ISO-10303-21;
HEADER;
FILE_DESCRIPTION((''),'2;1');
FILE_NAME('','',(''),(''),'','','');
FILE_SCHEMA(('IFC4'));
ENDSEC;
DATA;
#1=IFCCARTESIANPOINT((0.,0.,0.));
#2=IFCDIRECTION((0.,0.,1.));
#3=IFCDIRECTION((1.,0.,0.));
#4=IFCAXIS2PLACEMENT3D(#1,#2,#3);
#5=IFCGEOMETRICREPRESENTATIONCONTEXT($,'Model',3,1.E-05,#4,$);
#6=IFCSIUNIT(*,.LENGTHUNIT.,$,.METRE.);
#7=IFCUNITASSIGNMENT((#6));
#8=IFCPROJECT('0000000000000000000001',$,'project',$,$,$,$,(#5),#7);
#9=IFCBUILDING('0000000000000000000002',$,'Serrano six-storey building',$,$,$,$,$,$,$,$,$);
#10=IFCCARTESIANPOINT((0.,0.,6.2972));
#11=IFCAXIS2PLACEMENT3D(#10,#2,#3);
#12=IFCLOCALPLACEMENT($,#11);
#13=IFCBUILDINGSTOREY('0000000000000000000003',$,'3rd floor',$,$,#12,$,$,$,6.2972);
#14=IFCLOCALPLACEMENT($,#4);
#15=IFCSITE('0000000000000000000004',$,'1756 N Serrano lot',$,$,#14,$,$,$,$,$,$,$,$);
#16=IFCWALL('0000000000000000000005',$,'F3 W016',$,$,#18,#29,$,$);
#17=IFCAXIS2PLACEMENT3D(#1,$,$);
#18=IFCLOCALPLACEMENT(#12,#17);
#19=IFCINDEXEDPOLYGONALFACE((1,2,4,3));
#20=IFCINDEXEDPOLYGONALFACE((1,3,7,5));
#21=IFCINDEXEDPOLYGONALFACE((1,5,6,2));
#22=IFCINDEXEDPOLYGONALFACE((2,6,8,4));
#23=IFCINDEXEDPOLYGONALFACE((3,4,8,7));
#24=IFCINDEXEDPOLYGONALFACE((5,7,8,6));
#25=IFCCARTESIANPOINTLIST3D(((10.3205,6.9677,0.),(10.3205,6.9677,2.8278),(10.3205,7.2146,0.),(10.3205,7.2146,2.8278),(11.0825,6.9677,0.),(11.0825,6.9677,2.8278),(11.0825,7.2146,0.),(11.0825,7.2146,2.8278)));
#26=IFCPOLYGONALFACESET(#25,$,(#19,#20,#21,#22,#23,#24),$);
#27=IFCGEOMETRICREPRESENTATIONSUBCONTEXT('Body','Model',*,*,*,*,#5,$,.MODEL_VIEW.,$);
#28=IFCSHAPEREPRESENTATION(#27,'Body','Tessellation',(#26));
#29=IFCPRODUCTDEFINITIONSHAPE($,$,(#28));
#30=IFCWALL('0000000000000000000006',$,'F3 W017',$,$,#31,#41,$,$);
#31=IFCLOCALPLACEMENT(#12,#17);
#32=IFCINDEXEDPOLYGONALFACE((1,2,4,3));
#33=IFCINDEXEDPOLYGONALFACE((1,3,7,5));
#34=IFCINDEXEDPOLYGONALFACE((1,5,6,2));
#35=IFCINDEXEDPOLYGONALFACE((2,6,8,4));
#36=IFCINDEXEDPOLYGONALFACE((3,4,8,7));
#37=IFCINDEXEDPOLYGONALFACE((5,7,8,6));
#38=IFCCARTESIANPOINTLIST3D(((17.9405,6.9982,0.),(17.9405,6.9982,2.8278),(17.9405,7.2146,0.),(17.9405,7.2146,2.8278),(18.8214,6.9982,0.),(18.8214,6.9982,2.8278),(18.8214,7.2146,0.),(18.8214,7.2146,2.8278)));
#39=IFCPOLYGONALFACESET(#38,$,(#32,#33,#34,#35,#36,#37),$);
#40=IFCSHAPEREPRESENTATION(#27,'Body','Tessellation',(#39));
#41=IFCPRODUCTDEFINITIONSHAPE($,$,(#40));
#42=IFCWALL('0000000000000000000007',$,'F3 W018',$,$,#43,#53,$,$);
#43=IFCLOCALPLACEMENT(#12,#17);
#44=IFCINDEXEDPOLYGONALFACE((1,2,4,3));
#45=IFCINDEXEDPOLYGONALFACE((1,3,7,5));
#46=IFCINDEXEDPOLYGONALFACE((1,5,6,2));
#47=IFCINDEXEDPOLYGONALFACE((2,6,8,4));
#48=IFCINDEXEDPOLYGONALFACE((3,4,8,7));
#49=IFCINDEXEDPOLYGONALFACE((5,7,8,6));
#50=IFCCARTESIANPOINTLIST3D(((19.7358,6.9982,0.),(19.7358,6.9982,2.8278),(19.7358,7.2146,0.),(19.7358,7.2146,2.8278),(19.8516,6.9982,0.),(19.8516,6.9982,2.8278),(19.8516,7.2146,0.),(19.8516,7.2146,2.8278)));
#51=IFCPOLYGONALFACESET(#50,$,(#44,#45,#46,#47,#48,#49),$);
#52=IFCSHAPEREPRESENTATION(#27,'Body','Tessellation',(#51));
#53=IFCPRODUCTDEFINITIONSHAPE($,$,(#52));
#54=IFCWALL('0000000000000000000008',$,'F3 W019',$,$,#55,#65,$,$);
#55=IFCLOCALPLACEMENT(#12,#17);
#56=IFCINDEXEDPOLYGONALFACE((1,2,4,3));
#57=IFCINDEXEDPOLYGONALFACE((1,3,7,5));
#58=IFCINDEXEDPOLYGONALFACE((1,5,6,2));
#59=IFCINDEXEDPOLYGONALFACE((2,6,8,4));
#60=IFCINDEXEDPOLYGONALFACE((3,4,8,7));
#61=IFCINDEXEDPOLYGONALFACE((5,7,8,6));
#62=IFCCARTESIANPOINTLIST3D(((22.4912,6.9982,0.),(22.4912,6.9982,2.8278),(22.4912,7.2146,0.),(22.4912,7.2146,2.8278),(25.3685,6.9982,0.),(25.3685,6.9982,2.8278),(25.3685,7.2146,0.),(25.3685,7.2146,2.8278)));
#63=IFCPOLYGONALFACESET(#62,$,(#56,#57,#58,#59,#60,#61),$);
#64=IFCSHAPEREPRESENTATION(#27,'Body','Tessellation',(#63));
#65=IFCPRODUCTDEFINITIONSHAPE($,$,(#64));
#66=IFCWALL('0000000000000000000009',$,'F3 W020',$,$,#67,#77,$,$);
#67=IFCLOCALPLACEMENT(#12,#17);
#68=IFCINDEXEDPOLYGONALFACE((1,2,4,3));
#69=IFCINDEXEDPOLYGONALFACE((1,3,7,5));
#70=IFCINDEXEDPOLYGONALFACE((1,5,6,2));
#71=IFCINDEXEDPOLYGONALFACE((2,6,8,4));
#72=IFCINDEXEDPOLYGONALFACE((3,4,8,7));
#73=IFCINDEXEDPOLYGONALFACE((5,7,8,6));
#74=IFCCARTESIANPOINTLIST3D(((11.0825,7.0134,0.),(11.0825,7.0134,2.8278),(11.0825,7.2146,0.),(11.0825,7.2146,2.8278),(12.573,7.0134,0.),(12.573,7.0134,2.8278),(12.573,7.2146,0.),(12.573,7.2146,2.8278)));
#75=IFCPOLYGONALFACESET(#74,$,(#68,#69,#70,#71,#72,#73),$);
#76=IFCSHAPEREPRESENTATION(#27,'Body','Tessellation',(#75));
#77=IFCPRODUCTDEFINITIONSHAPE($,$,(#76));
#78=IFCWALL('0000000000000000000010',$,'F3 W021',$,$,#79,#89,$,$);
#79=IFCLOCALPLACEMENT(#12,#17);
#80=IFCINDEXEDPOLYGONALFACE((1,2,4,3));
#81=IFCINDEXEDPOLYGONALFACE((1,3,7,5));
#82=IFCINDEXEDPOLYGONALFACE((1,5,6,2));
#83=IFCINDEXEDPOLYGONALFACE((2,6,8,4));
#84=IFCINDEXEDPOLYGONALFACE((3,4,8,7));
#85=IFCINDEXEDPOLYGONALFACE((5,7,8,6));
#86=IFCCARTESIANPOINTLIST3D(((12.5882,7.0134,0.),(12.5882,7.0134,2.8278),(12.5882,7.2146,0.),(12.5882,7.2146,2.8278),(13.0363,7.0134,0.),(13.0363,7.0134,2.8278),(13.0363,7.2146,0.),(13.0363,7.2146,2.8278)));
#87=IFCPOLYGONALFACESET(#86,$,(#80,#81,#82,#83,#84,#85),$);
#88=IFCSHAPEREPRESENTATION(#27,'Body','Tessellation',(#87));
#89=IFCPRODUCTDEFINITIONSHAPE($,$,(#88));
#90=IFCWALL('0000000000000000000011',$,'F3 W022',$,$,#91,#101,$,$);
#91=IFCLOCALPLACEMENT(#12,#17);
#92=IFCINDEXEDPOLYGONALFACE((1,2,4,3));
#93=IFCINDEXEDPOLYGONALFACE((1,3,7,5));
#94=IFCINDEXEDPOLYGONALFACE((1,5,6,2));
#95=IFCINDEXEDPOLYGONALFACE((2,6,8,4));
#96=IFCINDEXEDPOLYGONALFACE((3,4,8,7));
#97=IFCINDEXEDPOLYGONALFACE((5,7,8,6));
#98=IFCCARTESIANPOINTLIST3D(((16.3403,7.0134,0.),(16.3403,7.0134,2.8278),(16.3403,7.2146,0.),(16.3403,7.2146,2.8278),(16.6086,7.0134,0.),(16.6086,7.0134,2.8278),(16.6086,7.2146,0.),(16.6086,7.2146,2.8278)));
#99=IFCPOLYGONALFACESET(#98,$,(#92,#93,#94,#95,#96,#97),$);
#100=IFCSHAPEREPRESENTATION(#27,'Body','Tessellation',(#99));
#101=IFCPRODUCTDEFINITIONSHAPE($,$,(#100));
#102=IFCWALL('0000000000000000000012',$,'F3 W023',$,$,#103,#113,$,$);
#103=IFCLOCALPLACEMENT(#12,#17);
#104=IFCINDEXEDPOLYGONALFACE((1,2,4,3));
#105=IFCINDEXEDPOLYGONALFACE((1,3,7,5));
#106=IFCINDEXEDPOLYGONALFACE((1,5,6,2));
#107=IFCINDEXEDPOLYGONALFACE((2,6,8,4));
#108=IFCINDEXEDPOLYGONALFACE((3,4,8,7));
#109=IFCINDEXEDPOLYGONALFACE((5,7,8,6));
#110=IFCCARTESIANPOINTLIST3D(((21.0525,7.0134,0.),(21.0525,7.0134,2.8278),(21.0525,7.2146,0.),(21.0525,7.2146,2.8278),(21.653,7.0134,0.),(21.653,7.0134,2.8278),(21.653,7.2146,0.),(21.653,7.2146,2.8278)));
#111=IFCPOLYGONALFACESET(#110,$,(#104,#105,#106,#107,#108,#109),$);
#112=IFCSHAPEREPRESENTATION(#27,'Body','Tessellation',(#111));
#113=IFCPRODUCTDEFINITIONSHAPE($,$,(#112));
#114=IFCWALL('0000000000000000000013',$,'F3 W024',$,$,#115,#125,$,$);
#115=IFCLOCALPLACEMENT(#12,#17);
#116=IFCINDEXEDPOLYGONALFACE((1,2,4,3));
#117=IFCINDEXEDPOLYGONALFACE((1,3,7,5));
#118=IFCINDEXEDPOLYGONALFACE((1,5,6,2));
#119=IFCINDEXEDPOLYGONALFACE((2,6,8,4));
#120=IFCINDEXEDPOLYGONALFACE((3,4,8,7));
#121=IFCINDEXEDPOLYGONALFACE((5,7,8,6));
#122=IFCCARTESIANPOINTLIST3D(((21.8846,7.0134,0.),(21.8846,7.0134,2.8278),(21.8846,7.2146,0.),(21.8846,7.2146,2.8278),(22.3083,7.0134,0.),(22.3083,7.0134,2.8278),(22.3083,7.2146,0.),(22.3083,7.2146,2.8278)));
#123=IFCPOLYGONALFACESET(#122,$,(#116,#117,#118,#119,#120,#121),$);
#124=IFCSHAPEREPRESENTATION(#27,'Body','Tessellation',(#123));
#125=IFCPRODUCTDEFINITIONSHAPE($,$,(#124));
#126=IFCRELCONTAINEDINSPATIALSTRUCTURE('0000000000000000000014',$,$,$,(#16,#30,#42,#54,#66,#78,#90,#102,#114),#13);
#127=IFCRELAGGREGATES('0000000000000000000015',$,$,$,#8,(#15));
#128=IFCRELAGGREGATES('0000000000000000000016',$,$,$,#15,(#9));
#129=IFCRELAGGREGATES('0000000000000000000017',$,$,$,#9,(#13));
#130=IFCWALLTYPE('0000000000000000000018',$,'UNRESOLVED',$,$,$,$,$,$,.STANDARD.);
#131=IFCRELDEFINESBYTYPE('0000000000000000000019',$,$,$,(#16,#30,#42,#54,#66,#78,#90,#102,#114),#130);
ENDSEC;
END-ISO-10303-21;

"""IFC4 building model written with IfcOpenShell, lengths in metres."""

from ifc_helpers import new_model, si_unit, frame, origin_with_axes, place, context, subcontext, project, spatial, polyline, outline, extrude, type_object, element, save


model = new_model("IFC4")

# Units and contexts
model_context = context("Model", 3, precision=1e-05, world=origin_with_axes())
body_context = subcontext(model_context, "Body", "Model", "MODEL_VIEW")
ifc_project = project(units=[si_unit("LENGTHUNIT", "METRE")], contexts=[model_context])

# Site, building, storey
site_placement = place(None, origin_with_axes())
site = spatial("IfcSite", under=ifc_project, at=site_placement, Name="1756 N Serrano lot")
building = spatial("IfcBuilding", under=site, Name="Serrano six-storey building")
storey_placement = place(None, frame((0.0, 0.0, 6.2972), z_axis=(0.0, 0.0, 1.0), x_axis=(1.0, 0.0, 0.0)))
storey = spatial("IfcBuildingStorey", under=building, at=storey_placement, Name="3rd floor", Elevation=6.2972)

# Walls
wall_type = type_object("IfcWallType", Name="UNRESOLVED", PredefinedType="STANDARD")
wall_1_placement = place(storey_placement, frame((0.0, 0.0, -6.2972), z_axis=(0.0, 0.0, 1.0), x_axis=(1.0, 0.0, 0.0)))
element("IfcWall", 1, at=wall_1_placement, inside=storey, type_object=wall_type, Name="F3 W016", context=body_context, shape_type="SweptSolid", body=[
    extrude(outline(polyline([(11.0825, 7.2146), (11.0825, 6.9677), (10.3205, 6.9677), (10.3205, 7.2146), (11.0825, 7.2146)])), frame((0.0, 0.0, 6.2972)), (0.0, 0.0, 1.0), 2.8278),
])
wall_2_placement = place(storey_placement, frame((0.0, 0.0, -6.2972), z_axis=(0.0, 0.0, 1.0), x_axis=(1.0, 0.0, 0.0)))
element("IfcWall", 2, at=wall_2_placement, inside=storey, type_object=wall_type, Name="F3 W017", context=body_context, shape_type="SweptSolid", body=[
    extrude(outline(polyline([(18.8214, 7.2146), (18.8214, 6.9982), (17.9405, 6.9982), (17.9405, 7.2146), (18.8214, 7.2146)])), frame((0.0, 0.0, 6.2972)), (0.0, 0.0, 1.0), 2.8278),
])
wall_3_placement = place(storey_placement, frame((0.0, 0.0, -6.2972), z_axis=(0.0, 0.0, 1.0), x_axis=(1.0, 0.0, 0.0)))
element("IfcWall", 3, at=wall_3_placement, inside=storey, type_object=wall_type, Name="F3 W018", context=body_context, shape_type="SweptSolid", body=[
    extrude(outline(polyline([(19.8516, 7.2146), (19.8516, 6.9982), (19.7358, 6.9982), (19.7358, 7.2146), (19.8516, 7.2146)])), frame((0.0, 0.0, 6.2972)), (0.0, 0.0, 1.0), 2.8278),
])
wall_4_placement = place(storey_placement, frame((0.0, 0.0, -6.2972), z_axis=(0.0, 0.0, 1.0), x_axis=(1.0, 0.0, 0.0)))
element("IfcWall", 4, at=wall_4_placement, inside=storey, type_object=wall_type, Name="F3 W019", context=body_context, shape_type="SweptSolid", body=[
    extrude(outline(polyline([(25.3685, 7.2146), (25.3685, 6.9982), (22.4912, 6.9982), (22.4912, 7.2146), (25.3685, 7.2146)])), frame((0.0, 0.0, 6.2972)), (0.0, 0.0, 1.0), 2.8278),
])
wall_5_placement = place(storey_placement, frame((0.0, 0.0, -6.2972), z_axis=(0.0, 0.0, 1.0), x_axis=(1.0, 0.0, 0.0)))
element("IfcWall", 5, at=wall_5_placement, inside=storey, type_object=wall_type, Name="F3 W020", context=body_context, shape_type="SweptSolid", body=[
    extrude(outline(polyline([(12.573, 7.2146), (12.573, 7.0134), (11.0825, 7.0134), (11.0825, 7.2146), (12.573, 7.2146)])), frame((0.0, 0.0, 6.2972)), (0.0, 0.0, 1.0), 2.8278),
])
wall_6_placement = place(storey_placement, frame((0.0, 0.0, -6.2972), z_axis=(0.0, 0.0, 1.0), x_axis=(1.0, 0.0, 0.0)))
element("IfcWall", 6, at=wall_6_placement, inside=storey, type_object=wall_type, Name="F3 W021", context=body_context, shape_type="SweptSolid", body=[
    extrude(outline(polyline([(13.0363, 7.2146), (13.0363, 7.0134), (12.5882, 7.0134), (12.5882, 7.2146), (13.0363, 7.2146)])), frame((0.0, 0.0, 6.2972)), (0.0, 0.0, 1.0), 2.8278),
])
wall_7_placement = place(storey_placement, frame((0.0, 0.0, -6.2972), z_axis=(0.0, 0.0, 1.0), x_axis=(1.0, 0.0, 0.0)))
element("IfcWall", 7, at=wall_7_placement, inside=storey, type_object=wall_type, Name="F3 W022", context=body_context, shape_type="SweptSolid", body=[
    extrude(outline(polyline([(16.6086, 7.2146), (16.6086, 7.0134), (16.3403, 7.0134), (16.3403, 7.2146), (16.6086, 7.2146)])), frame((0.0, 0.0, 6.2972)), (0.0, 0.0, 1.0), 2.8278),
])
wall_8_placement = place(storey_placement, frame((0.0, 0.0, -6.2972), z_axis=(0.0, 0.0, 1.0), x_axis=(1.0, 0.0, 0.0)))
element("IfcWall", 8, at=wall_8_placement, inside=storey, type_object=wall_type, Name="F3 W023", context=body_context, shape_type="SweptSolid", body=[
    extrude(outline(polyline([(21.653, 7.2146), (21.653, 7.0134), (21.0525, 7.0134), (21.0525, 7.2146), (21.653, 7.2146)])), frame((0.0, 0.0, 6.2972)), (0.0, 0.0, 1.0), 2.8278),
])
wall_9_placement = place(storey_placement, frame((0.0, 0.0, -6.2972), z_axis=(0.0, 0.0, 1.0), x_axis=(1.0, 0.0, 0.0)))
element("IfcWall", 9, at=wall_9_placement, inside=storey, type_object=wall_type, Name="F3 W024", context=body_context, shape_type="SweptSolid", body=[
    extrude(outline(polyline([(22.3083, 7.2146), (22.3083, 7.0134), (21.8846, 7.0134), (21.8846, 7.2146), (22.3083, 7.2146)])), frame((0.0, 0.0, 6.2972)), (0.0, 0.0, 1.0), 2.8278),
])

save(model, "model.ifc")
